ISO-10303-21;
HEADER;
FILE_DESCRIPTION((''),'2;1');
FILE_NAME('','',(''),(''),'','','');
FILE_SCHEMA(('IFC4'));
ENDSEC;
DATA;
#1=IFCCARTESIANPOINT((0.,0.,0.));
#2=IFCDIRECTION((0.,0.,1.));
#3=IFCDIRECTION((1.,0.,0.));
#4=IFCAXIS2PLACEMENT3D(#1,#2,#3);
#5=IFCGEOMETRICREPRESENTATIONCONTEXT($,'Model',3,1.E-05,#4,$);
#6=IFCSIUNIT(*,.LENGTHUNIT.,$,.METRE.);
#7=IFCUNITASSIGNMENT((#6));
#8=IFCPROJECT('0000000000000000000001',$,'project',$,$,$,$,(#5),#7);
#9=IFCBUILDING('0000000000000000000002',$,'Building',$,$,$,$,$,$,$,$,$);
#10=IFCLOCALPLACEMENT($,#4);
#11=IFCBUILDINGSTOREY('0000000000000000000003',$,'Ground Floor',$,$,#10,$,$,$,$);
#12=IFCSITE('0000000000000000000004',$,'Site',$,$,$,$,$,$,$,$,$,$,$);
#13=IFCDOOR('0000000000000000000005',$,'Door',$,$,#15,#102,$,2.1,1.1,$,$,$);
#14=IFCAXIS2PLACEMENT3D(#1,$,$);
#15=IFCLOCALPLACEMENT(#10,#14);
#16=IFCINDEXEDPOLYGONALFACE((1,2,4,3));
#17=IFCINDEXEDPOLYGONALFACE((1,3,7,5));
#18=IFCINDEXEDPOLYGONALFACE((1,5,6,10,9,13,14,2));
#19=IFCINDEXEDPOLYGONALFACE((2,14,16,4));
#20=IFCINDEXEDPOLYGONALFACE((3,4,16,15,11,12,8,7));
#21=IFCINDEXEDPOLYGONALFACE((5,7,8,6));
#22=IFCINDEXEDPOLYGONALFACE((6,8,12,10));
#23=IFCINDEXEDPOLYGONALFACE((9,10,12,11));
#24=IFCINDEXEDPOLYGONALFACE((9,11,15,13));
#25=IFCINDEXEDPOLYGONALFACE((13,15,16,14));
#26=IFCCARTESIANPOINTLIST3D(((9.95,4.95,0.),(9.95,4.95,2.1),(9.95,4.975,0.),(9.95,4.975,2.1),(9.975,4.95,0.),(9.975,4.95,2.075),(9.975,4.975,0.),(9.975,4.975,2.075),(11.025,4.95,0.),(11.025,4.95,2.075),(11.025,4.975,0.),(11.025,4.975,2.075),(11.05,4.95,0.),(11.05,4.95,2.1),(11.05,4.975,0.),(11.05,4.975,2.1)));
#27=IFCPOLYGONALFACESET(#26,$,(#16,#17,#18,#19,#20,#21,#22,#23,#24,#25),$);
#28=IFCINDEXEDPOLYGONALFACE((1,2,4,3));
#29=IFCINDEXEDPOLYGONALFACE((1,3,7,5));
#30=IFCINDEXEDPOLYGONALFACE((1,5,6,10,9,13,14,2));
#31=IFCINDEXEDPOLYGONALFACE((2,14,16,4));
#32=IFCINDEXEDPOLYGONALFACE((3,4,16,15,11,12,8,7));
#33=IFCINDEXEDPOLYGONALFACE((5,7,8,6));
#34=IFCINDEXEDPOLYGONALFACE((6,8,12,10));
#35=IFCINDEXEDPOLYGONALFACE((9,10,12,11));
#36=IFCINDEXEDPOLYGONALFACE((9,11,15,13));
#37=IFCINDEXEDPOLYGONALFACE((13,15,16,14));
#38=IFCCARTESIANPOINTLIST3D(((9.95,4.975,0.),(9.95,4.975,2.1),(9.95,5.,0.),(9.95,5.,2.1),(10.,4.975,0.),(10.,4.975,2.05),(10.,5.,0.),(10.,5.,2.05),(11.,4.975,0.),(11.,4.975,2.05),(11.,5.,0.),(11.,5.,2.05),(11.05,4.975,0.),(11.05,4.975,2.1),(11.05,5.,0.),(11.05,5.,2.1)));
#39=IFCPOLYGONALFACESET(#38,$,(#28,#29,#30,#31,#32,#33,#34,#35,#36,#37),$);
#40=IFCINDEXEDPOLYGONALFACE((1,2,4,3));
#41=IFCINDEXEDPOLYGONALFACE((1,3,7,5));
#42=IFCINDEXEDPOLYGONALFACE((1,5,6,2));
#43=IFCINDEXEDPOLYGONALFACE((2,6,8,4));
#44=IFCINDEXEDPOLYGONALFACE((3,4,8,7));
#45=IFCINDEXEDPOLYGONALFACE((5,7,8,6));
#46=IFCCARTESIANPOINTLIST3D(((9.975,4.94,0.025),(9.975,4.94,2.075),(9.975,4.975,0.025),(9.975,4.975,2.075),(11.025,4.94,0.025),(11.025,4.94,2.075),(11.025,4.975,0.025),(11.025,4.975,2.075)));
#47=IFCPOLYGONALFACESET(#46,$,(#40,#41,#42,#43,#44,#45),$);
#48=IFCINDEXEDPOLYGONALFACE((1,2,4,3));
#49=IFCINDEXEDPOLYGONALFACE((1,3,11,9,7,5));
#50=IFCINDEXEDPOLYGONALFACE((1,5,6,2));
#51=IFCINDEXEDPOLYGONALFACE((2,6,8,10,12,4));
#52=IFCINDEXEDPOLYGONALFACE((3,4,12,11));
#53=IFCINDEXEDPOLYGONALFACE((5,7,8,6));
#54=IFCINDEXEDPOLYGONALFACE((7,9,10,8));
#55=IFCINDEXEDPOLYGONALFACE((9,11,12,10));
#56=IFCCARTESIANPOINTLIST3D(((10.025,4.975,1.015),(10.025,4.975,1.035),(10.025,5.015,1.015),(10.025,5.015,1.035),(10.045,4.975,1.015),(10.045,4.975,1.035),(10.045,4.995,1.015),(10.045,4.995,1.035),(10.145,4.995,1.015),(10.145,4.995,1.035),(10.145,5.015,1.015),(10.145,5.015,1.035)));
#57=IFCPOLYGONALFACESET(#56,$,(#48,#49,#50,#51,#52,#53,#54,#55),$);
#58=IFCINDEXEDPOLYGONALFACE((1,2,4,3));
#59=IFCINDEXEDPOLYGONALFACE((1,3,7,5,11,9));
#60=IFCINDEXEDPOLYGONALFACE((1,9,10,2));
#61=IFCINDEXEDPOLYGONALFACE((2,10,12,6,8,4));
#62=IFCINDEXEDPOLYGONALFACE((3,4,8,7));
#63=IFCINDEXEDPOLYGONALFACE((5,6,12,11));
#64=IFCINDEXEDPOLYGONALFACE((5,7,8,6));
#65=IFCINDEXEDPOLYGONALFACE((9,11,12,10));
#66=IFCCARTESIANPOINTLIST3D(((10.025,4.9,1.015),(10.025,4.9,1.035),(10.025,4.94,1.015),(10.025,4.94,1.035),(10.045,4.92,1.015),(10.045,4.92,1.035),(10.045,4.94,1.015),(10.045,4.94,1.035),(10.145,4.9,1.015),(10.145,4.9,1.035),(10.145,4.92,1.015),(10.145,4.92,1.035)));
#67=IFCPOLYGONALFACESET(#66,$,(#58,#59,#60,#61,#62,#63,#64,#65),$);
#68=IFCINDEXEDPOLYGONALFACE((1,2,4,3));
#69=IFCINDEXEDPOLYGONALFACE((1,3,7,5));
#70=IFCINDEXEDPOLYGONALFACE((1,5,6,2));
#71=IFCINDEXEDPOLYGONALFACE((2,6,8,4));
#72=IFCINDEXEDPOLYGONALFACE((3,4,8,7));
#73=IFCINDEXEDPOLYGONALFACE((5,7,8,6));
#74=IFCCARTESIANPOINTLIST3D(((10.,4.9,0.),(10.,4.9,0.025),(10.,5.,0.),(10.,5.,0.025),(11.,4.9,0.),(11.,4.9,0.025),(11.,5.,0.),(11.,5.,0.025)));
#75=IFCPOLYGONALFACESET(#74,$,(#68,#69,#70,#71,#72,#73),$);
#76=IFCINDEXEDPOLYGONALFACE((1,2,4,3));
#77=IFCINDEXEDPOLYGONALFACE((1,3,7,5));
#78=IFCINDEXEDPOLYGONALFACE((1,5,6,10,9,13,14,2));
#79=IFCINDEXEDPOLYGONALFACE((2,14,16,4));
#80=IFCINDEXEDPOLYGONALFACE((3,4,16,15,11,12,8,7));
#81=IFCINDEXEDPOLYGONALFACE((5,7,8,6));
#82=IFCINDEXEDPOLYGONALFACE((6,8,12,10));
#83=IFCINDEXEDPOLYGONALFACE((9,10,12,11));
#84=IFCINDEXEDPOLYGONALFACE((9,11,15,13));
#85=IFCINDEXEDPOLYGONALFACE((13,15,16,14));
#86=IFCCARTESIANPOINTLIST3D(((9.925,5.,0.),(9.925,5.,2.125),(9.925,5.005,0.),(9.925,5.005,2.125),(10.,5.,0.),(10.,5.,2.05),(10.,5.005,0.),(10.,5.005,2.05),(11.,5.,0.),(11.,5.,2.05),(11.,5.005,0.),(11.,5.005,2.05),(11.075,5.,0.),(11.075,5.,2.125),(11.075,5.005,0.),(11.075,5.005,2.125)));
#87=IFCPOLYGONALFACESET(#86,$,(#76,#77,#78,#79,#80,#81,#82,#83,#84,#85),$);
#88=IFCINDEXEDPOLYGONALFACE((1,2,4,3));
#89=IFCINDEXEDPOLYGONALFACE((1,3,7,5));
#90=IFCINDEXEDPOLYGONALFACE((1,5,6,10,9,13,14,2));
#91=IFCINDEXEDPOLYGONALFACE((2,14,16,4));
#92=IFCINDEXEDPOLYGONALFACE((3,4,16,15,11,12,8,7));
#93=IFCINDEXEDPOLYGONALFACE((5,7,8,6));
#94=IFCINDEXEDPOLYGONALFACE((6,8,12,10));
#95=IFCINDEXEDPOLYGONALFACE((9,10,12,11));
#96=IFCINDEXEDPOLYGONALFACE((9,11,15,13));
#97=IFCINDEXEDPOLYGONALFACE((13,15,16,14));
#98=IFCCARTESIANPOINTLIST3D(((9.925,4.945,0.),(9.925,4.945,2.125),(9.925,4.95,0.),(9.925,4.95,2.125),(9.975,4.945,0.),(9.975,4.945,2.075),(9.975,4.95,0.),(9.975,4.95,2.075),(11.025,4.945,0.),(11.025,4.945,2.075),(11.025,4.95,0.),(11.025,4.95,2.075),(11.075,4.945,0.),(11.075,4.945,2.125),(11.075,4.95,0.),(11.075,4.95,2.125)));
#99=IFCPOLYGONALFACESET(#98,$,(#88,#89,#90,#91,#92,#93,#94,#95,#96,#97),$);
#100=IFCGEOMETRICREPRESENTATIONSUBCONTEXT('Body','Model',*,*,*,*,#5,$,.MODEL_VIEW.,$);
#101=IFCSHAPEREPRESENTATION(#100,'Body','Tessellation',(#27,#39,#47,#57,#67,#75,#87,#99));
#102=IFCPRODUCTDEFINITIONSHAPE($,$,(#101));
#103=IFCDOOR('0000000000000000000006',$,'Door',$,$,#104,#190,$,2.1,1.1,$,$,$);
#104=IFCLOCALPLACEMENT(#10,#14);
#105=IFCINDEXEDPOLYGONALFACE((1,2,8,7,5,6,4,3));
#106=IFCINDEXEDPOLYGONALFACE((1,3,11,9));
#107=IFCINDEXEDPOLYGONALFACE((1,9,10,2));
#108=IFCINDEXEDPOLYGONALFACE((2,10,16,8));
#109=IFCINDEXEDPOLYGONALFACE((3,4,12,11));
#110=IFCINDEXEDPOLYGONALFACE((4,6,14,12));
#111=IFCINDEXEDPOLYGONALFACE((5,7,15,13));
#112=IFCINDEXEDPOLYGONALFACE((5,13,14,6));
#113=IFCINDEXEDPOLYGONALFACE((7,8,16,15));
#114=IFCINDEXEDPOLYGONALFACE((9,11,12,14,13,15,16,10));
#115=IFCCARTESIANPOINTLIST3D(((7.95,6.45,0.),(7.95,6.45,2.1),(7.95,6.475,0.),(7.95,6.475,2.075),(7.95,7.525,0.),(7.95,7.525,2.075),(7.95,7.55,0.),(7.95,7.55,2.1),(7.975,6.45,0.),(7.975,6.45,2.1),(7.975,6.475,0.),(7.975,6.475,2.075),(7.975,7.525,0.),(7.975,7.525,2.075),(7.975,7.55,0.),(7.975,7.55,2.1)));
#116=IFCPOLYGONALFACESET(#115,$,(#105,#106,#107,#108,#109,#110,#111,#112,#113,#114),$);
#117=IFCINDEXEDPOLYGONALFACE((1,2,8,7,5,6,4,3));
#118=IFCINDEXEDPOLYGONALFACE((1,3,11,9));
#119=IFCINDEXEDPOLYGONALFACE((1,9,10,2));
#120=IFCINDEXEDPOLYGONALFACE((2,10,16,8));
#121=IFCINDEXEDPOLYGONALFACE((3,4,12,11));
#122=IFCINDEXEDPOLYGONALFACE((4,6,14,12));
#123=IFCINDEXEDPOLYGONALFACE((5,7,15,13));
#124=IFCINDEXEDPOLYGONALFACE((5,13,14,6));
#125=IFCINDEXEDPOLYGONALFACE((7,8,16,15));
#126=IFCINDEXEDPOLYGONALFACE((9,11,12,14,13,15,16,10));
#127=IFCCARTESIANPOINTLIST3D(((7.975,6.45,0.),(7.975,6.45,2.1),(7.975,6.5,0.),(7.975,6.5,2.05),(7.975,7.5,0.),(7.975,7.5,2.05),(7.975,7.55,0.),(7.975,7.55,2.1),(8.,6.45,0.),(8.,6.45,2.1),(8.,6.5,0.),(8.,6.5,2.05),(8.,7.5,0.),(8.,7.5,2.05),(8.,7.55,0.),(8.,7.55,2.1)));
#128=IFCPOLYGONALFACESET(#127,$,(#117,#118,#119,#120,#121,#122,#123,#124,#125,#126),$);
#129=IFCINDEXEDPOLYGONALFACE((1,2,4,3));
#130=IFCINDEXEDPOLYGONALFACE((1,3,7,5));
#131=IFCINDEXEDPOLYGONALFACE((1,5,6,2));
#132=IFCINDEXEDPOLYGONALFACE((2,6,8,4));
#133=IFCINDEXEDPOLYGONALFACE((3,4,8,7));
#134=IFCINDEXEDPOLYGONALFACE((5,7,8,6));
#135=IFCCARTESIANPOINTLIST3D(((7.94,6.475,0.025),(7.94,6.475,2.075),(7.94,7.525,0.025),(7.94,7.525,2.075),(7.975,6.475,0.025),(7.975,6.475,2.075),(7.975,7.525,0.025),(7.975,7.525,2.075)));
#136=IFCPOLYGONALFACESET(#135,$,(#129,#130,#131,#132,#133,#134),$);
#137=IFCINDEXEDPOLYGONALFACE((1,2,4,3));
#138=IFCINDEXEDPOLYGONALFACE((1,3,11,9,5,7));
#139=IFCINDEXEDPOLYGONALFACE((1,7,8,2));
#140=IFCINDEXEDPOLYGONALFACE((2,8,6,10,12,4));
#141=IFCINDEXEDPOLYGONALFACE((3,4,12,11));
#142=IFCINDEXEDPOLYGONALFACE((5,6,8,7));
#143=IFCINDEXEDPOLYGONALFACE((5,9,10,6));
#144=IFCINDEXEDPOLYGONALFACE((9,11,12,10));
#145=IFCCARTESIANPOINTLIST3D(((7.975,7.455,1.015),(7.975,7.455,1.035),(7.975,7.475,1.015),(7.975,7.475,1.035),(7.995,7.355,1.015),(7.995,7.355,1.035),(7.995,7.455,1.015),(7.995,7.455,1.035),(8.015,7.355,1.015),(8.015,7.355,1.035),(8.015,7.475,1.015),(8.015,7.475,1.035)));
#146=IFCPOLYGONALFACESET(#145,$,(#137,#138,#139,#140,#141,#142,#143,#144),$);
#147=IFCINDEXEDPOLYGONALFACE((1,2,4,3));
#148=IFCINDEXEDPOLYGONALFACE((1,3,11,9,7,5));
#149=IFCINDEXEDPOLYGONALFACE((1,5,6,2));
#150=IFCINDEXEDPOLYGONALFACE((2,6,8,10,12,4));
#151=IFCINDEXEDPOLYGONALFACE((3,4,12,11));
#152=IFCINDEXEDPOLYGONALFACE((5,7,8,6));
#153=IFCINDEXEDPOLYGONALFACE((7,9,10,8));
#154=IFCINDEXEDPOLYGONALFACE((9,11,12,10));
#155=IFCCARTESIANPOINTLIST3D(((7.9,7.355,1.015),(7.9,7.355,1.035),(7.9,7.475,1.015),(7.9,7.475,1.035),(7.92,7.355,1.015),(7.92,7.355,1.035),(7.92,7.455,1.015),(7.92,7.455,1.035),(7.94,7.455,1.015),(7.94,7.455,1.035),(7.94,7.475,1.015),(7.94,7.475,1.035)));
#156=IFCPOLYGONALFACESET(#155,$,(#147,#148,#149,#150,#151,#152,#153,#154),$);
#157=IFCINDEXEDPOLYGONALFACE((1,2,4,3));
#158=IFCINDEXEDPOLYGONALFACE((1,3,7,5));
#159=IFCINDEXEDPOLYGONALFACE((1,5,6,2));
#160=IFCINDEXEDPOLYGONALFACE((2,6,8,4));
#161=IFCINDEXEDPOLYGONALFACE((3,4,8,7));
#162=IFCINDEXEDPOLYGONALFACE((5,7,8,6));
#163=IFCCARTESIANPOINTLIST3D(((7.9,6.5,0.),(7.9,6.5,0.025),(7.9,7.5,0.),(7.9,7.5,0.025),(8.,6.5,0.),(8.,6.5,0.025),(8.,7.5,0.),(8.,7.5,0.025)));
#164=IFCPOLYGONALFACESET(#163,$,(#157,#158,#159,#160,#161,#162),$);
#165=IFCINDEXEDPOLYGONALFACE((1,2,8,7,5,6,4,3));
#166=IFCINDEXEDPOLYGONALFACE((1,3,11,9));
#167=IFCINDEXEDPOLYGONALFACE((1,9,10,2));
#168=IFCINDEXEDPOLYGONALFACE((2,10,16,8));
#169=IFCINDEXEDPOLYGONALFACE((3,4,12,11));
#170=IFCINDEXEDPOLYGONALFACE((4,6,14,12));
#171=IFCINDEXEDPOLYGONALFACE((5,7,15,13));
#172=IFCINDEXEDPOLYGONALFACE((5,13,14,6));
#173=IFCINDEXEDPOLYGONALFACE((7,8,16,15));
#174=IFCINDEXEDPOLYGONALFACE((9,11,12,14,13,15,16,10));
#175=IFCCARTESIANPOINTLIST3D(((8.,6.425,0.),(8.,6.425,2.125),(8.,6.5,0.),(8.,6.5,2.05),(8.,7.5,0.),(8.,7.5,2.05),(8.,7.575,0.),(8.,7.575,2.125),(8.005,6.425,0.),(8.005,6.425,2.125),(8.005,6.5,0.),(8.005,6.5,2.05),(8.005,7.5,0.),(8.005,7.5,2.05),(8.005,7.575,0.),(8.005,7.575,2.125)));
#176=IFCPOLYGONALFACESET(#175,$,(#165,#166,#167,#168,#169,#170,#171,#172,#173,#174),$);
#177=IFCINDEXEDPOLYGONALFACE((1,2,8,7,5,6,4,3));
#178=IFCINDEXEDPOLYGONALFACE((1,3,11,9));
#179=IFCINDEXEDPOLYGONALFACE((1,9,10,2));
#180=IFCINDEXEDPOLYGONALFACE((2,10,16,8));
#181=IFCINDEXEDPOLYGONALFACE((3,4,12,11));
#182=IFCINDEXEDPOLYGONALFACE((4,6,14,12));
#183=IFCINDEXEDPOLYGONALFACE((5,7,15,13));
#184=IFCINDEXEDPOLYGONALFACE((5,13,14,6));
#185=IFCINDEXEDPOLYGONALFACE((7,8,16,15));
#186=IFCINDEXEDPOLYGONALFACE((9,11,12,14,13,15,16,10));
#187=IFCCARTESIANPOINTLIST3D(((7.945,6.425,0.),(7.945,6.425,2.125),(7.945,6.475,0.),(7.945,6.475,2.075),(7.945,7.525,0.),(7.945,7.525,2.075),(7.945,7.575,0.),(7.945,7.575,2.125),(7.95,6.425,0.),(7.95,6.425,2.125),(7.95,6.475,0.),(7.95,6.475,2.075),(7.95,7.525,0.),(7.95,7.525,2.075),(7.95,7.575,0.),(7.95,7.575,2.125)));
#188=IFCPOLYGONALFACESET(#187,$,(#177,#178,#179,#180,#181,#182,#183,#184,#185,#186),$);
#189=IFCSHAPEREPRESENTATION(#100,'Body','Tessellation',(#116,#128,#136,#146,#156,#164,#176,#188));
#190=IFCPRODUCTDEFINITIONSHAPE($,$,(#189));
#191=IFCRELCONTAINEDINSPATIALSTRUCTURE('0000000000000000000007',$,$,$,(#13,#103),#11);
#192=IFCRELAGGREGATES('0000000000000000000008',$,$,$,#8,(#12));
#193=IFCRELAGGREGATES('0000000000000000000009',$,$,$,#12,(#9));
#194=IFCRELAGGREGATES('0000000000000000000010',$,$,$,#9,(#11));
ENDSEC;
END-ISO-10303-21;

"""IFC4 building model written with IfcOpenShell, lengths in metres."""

from ifc_helpers import new_model, si_unit, frame, origin_with_axes, place, context, subcontext, project, spatial, line, indexed_curve, outline, extrude, element, save


model = new_model("IFC4")

# Units and contexts
model_context = context("Model", 3, precision=1e-05, world=origin_with_axes())
body_context = subcontext(model_context, "Body", "Model", "MODEL_VIEW")
ifc_project = project(units=[si_unit("LENGTHUNIT", "METRE")], contexts=[model_context])

# Site, building, storey
site = spatial("IfcSite", under=ifc_project, Name="Site")
building = spatial("IfcBuilding", under=site, Name="Building")
storey_placement = place(None, origin_with_axes())
storey = spatial("IfcBuildingStorey", under=building, at=storey_placement, Name="Ground Floor")

# Doors
door_1_placement = place(storey_placement, frame((11.05, 5.0, 0.0), z_axis=(0.0, 0.0, 1.0), x_axis=(-1.0, 0.0, 0.0)))
element("IfcDoor", 1, at=door_1_placement, inside=storey, Name="Door", OverallHeight=2.1, OverallWidth=1.1, context=body_context, shape_type="SweptSolid", body=[
    extrude(outline(indexed_curve([(0.0, 0.0), (0.0, 2.1), (1.1, 2.1), (1.1, 0.0), (1.075, 0.0), (1.075, 2.075), (0.025, 2.075), (0.025, 0.0)], segments=[line(1, 2, 3, 4, 5, 6, 7, 8, 1)])), frame((0.0, 0.025, 0.0), z_axis=(0.0, -1.0, 0.0), x_axis=(1.0, 0.0, 0.0)), (0.0, 0.0, -1.0), 0.025),
    extrude(outline(indexed_curve([(0.0, 0.0), (0.0, 2.1), (1.1, 2.1), (1.1, 0.0), (1.05, 0.0), (1.05, 2.05), (0.05, 2.05), (0.05, 0.0)], segments=[line(1, 2, 3, 4, 5, 6, 7, 8, 1)])), frame((0.0, 0.0, 0.0), z_axis=(0.0, -1.0, 0.0), x_axis=(1.0, 0.0, 0.0)), (0.0, 0.0, -1.0), 0.025),
    extrude(outline(indexed_curve([(0.0, 0.0), (1.05, 0.0), (1.05, 0.035), (0.0, 0.035)], segments=[line(1, 2, 3, 4, 1)])), frame((0.025, 0.025, 0.025), z_axis=(0.0, 0.0, 1.0), x_axis=(1.0, 0.0, 0.0)), (0.0, 0.0, 1.0), 2.05),
    extrude(outline(indexed_curve([(0.0, 0.0), (0.0, -0.04), (-0.12, -0.04), (-0.12, -0.02), (-0.02, -0.02), (-0.02, 0.0)], segments=[line(1, 2, 3, 4, 5, 6, 1)])), frame((1.025, 0.025, 1.015), z_axis=(0.0, 0.0, 1.0), x_axis=(1.0, 0.0, 0.0)), (0.0, 0.0, 1.0), 0.02),
    extrude(outline(indexed_curve([(0.0, 0.0), (0.0, 0.04), (-0.12, 0.04), (-0.12, 0.02), (-0.02, 0.02), (-0.02, 0.0)], segments=[line(1, 2, 3, 4, 5, 6, 1)])), frame((1.025, 0.06, 1.015), z_axis=(0.0, 0.0, 1.0), x_axis=(1.0, 0.0, 0.0)), (0.0, 0.0, 1.0), 0.02),
    extrude(outline(indexed_curve([(0.0, 0.0), (1.0, 0.0), (1.0, 0.1), (0.0, 0.1)], segments=[line(1, 2, 3, 4, 1)])), frame((0.05, 0.0, 0.0), z_axis=(0.0, 0.0, 1.0), x_axis=(1.0, 0.0, 0.0)), (0.0, 0.0, 1.0), 0.025),
    extrude(outline(indexed_curve([(0.0, 0.0), (0.0, 2.125), (1.15, 2.125), (1.15, 0.0), (1.075, 0.0), (1.075, 2.05), (0.075, 2.05), (0.075, 0.0)], segments=[line(1, 2, 3, 4, 5, 6, 7, 8, 1)])), frame((-0.025, -0.005, 0.0), z_axis=(0.0, -1.0, 0.0), x_axis=(1.0, 0.0, 0.0)), (0.0, 0.0, -1.0), 0.005),
    extrude(outline(indexed_curve([(0.0, 0.0), (0.0, 2.125), (1.15, 2.125), (1.15, 0.0), (1.1, 0.0), (1.1, 2.075), (0.05, 2.075), (0.05, 0.0)], segments=[line(1, 2, 3, 4, 5, 6, 7, 8, 1)])), frame((-0.025, 0.05, 0.0), z_axis=(0.0, -1.0, 0.0), x_axis=(1.0, 0.0, 0.0)), (0.0, 0.0, -1.0), 0.005),
])
door_2_placement = place(storey_placement, frame((8.0, 6.45, 0.0), z_axis=(0.0, 0.0, 1.0), x_axis=(0.0, 1.0, 0.0)))
element("IfcDoor", 2, at=door_2_placement, inside=storey, Name="Door", OverallHeight=2.1, OverallWidth=1.1, context=body_context, shape_type="SweptSolid", body=[
    extrude(outline(indexed_curve([(0.0, 0.0), (0.0, 2.1), (1.1, 2.1), (1.1, 0.0), (1.075, 0.0), (1.075, 2.075), (0.025, 2.075), (0.025, 0.0)], segments=[line(1, 2, 3, 4, 5, 6, 7, 8, 1)])), frame((0.0, 0.025, 0.0), z_axis=(0.0, -1.0, 0.0), x_axis=(1.0, 0.0, 0.0)), (0.0, 0.0, -1.0), 0.025),
    extrude(outline(indexed_curve([(0.0, 0.0), (0.0, 2.1), (1.1, 2.1), (1.1, 0.0), (1.05, 0.0), (1.05, 2.05), (0.05, 2.05), (0.05, 0.0)], segments=[line(1, 2, 3, 4, 5, 6, 7, 8, 1)])), frame((0.0, 0.0, 0.0), z_axis=(0.0, -1.0, 0.0), x_axis=(1.0, 0.0, 0.0)), (0.0, 0.0, -1.0), 0.025),
    extrude(outline(indexed_curve([(0.0, 0.0), (1.05, 0.0), (1.05, 0.035), (0.0, 0.035)], segments=[line(1, 2, 3, 4, 1)])), frame((0.025, 0.025, 0.025), z_axis=(0.0, 0.0, 1.0), x_axis=(1.0, 0.0, 0.0)), (0.0, 0.0, 1.0), 2.05),
    extrude(outline(indexed_curve([(0.0, 0.0), (0.0, -0.04), (-0.12, -0.04), (-0.12, -0.02), (-0.02, -0.02), (-0.02, 0.0)], segments=[line(1, 2, 3, 4, 5, 6, 1)])), frame((1.025, 0.025, 1.015), z_axis=(0.0, 0.0, 1.0), x_axis=(1.0, 0.0, 0.0)), (0.0, 0.0, 1.0), 0.02),
    extrude(outline(indexed_curve([(0.0, 0.0), (0.0, 0.04), (-0.12, 0.04), (-0.12, 0.02), (-0.02, 0.02), (-0.02, 0.0)], segments=[line(1, 2, 3, 4, 5, 6, 1)])), frame((1.025, 0.06, 1.015), z_axis=(0.0, 0.0, 1.0), x_axis=(1.0, 0.0, 0.0)), (0.0, 0.0, 1.0), 0.02),
    extrude(outline(indexed_curve([(0.0, 0.0), (1.0, 0.0), (1.0, 0.1), (0.0, 0.1)], segments=[line(1, 2, 3, 4, 1)])), frame((0.05, 0.0, 0.0), z_axis=(0.0, 0.0, 1.0), x_axis=(1.0, 0.0, 0.0)), (0.0, 0.0, 1.0), 0.025),
    extrude(outline(indexed_curve([(0.0, 0.0), (0.0, 2.125), (1.15, 2.125), (1.15, 0.0), (1.075, 0.0), (1.075, 2.05), (0.075, 2.05), (0.075, 0.0)], segments=[line(1, 2, 3, 4, 5, 6, 7, 8, 1)])), frame((-0.025, -0.005, 0.0), z_axis=(0.0, -1.0, 0.0), x_axis=(1.0, 0.0, 0.0)), (0.0, 0.0, -1.0), 0.005),
    extrude(outline(indexed_curve([(0.0, 0.0), (0.0, 2.125), (1.15, 2.125), (1.15, 0.0), (1.1, 0.0), (1.1, 2.075), (0.05, 2.075), (0.05, 0.0)], segments=[line(1, 2, 3, 4, 5, 6, 7, 8, 1)])), frame((-0.025, 0.05, 0.0), z_axis=(0.0, -1.0, 0.0), x_axis=(1.0, 0.0, 0.0)), (0.0, 0.0, -1.0), 0.005),
])

save(model, "model.ifc")
